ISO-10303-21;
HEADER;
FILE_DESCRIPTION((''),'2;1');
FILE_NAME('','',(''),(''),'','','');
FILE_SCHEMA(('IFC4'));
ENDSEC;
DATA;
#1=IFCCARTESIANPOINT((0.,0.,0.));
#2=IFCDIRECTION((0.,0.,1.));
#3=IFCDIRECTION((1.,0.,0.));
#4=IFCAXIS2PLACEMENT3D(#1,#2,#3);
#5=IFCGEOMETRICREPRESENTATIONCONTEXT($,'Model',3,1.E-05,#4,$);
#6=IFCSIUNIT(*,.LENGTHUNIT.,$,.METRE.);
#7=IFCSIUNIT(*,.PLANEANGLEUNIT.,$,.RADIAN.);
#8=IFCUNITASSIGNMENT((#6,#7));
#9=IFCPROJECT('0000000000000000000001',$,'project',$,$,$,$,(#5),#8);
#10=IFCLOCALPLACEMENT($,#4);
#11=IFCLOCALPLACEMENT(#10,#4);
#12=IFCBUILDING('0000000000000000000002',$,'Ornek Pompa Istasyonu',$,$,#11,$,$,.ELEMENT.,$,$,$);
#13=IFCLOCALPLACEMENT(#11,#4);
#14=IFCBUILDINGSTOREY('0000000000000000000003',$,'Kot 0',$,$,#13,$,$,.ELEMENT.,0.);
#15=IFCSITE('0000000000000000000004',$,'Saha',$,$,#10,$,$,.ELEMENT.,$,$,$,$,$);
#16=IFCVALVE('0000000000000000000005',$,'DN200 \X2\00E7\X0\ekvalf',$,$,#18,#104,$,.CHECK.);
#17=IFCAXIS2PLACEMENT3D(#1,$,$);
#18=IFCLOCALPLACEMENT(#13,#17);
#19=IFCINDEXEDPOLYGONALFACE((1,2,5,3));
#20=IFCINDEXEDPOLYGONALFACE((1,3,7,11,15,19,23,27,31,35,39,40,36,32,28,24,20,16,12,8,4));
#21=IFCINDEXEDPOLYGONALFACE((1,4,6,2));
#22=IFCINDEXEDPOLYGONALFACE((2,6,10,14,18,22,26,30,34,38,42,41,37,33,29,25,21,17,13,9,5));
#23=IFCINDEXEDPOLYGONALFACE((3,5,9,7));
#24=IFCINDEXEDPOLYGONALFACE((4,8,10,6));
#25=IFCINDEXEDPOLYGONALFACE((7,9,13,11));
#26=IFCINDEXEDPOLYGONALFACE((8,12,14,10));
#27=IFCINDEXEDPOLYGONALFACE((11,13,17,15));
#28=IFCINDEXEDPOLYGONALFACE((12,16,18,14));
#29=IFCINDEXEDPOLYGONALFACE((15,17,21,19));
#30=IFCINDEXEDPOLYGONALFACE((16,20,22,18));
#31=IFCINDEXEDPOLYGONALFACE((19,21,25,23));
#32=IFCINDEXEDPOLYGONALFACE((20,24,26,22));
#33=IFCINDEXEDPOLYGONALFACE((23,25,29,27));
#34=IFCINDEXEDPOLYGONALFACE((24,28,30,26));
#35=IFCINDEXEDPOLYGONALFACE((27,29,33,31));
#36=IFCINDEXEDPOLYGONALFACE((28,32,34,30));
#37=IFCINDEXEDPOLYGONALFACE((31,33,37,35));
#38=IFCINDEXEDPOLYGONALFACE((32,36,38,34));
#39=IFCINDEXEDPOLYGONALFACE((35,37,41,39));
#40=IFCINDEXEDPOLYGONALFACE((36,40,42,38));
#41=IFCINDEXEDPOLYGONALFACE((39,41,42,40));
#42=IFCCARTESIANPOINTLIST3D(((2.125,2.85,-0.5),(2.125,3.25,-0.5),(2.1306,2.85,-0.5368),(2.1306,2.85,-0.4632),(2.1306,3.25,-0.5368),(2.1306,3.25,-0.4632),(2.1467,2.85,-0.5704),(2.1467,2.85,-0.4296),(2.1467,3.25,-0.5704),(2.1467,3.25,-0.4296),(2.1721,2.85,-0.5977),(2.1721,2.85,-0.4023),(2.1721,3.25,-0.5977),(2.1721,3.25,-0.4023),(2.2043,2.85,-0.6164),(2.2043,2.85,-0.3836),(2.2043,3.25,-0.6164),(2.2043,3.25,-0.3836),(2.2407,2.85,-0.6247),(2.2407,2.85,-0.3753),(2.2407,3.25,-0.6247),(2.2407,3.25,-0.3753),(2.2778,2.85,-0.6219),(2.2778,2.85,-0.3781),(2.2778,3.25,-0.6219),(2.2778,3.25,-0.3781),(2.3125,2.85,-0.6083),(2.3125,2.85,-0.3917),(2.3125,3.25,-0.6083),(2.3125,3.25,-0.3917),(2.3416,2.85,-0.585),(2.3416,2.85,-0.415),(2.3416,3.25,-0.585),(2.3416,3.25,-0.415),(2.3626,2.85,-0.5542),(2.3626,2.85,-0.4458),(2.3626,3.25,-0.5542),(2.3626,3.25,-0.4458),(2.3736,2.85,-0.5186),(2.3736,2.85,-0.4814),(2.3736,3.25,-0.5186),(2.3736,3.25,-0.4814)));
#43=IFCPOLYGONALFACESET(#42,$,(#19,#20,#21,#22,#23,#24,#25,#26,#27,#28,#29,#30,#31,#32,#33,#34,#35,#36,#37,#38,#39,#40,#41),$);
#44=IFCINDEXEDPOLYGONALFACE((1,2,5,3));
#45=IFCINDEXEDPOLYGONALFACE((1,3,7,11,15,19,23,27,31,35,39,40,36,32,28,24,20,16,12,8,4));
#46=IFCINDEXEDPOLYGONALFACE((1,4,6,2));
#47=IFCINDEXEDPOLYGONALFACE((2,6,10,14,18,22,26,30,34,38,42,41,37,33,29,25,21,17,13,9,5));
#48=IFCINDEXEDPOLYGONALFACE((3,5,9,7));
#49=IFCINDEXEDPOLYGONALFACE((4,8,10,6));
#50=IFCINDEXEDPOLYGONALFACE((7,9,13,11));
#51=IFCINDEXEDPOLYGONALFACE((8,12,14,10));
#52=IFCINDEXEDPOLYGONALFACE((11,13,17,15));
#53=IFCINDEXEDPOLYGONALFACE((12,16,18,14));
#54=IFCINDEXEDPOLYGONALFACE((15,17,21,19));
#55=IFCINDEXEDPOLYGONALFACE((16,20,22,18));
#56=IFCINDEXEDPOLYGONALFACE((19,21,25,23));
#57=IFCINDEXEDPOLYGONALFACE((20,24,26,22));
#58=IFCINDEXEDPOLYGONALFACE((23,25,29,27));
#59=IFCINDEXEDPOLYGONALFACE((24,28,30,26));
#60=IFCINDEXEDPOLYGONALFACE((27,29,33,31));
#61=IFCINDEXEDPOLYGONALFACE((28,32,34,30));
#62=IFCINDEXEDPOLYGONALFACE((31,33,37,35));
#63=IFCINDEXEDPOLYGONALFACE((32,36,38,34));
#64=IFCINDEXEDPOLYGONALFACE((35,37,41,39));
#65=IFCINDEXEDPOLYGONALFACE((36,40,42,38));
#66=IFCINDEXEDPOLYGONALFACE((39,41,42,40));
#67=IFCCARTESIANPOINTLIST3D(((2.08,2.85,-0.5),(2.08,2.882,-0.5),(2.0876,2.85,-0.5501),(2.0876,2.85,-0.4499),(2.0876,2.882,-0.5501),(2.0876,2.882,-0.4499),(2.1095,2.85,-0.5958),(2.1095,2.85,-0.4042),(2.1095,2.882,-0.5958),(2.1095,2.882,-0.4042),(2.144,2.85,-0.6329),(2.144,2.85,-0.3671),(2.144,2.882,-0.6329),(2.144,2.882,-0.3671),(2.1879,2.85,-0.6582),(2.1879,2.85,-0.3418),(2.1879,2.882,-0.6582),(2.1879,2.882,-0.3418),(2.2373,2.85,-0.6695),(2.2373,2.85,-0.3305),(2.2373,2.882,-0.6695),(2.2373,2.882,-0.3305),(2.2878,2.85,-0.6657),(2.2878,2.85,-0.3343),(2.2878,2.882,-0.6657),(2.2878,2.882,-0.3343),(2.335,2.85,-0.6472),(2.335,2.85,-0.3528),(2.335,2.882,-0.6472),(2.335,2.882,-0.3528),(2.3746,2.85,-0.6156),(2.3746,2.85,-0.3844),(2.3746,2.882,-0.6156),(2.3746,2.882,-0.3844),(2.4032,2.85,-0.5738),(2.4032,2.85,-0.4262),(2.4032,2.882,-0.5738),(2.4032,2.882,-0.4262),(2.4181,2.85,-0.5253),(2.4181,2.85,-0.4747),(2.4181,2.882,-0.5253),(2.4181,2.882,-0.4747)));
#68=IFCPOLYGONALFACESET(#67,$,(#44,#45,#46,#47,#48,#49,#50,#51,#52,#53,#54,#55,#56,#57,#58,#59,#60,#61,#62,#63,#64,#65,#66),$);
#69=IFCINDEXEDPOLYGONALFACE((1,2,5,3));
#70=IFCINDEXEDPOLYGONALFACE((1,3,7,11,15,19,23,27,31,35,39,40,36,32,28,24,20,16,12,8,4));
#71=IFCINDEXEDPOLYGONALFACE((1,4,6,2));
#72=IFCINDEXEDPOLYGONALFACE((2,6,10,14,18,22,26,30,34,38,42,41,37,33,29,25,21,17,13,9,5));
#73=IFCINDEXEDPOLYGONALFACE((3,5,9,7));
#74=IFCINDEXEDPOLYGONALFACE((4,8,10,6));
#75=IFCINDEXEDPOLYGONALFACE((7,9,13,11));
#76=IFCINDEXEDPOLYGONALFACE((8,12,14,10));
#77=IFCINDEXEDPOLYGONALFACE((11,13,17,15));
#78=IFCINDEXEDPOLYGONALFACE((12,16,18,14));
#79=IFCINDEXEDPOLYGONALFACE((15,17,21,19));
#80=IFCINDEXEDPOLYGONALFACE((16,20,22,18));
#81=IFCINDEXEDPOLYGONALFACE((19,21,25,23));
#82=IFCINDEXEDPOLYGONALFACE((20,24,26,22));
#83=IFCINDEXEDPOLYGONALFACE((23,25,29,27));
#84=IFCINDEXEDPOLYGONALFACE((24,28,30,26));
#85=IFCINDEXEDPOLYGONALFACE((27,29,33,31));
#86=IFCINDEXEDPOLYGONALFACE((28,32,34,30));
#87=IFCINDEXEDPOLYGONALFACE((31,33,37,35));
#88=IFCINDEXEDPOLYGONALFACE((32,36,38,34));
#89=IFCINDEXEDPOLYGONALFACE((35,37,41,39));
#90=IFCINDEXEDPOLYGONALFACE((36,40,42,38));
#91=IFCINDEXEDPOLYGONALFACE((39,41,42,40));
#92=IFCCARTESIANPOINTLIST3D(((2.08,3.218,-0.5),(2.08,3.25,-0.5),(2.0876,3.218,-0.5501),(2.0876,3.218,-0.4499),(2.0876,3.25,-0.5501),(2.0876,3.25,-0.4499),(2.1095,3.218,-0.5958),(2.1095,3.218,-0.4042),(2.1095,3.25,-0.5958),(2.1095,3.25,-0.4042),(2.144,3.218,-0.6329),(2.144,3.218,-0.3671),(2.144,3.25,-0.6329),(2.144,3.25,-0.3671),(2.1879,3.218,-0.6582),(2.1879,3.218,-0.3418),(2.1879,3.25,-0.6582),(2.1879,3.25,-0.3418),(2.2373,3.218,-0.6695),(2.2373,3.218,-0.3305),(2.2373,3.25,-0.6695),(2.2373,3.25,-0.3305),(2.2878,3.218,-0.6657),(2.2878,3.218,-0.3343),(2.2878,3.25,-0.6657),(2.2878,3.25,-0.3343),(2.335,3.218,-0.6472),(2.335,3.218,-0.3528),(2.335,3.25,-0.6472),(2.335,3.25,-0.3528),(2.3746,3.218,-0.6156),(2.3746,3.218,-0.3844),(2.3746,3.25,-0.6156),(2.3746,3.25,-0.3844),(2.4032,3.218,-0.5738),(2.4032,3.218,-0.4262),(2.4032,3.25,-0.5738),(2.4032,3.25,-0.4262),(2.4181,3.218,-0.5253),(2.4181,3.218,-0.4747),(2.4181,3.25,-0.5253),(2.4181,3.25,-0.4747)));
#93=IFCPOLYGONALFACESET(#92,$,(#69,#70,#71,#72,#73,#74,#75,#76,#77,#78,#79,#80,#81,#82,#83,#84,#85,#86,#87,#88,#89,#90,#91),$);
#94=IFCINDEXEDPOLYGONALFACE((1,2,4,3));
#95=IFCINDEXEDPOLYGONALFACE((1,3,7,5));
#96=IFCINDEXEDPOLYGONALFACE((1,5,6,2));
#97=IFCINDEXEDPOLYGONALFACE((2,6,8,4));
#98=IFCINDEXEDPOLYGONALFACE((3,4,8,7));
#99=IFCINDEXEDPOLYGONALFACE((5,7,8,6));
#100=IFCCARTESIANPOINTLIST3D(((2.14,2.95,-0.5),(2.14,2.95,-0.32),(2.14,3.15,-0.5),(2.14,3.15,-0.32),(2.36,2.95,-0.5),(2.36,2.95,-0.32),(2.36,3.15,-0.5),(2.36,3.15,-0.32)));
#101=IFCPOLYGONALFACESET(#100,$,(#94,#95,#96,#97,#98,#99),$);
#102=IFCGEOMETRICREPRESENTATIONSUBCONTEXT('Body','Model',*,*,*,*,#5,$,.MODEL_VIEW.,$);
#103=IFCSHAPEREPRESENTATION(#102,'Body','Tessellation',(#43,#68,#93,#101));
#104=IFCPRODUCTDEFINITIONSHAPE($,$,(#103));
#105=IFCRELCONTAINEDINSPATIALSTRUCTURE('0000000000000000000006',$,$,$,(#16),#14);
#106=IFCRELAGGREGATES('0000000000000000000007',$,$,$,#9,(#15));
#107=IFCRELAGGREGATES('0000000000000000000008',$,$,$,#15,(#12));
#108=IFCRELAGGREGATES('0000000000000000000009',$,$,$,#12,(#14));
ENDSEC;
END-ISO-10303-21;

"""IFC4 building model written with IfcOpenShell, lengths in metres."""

from ifc_helpers import new_model, si_unit, frame, origin_with_axes, origin_2d, place, context, subcontext, project, spatial, polyline, circle, outline, extrude, element, save


model = new_model("IFC4")

# Units and contexts
model_context = context("Model", 3, precision=1e-05, world=origin_with_axes())
body_context = subcontext(model_context, "Body", "Model", "MODEL_VIEW")
ifc_project = project(units=[si_unit("LENGTHUNIT", "METRE"), si_unit("PLANEANGLEUNIT", "RADIAN")], contexts=[model_context])

# Site, building, storey
site_placement = place(None, origin_with_axes())
site = spatial("IfcSite", under=ifc_project, at=site_placement, Name="Saha", CompositionType="ELEMENT")
building_placement = place(site_placement, origin_with_axes())
building = spatial("IfcBuilding", under=site, at=building_placement, Name="Ornek Pompa Istasyonu", CompositionType="ELEMENT")
storey_placement = place(building_placement, origin_with_axes())
storey = spatial("IfcBuildingStorey", under=building, at=storey_placement, Name="Kot 0", CompositionType="ELEMENT", Elevation=0.0)

# Valve
valve_1_placement = place(storey_placement, origin_with_axes())
element("IfcValve", 1, at=valve_1_placement, inside=storey, Name="DN200 çekvalf", PredefinedType="CHECK", context=body_context, shape_type="SweptSolid", body=[
    extrude(circle(Radius=0.125, at=origin_2d()), frame((2.25, 2.85, -0.5), z_axis=(0.0, 1.0, 0.0), x_axis=(-1.0, 0.0, 0.0)), (0.0, 0.0, 1.0), 0.4),
    extrude(circle(Radius=0.17, at=origin_2d()), frame((2.25, 2.85, -0.5), z_axis=(0.0, 1.0, 0.0), x_axis=(-1.0, 0.0, 0.0)), (0.0, 0.0, 1.0), 0.032),
    extrude(circle(Radius=0.17, at=origin_2d()), frame((2.25, 3.218, -0.5), z_axis=(0.0, 1.0, 0.0), x_axis=(-1.0, 0.0, 0.0)), (0.0, 0.0, 1.0), 0.032),
    extrude(outline(polyline([(0.0, 0.0), (0.2, 0.0), (0.2, 0.22), (0.0, 0.22), (0.0, 0.0)])), frame((2.36, 2.95, -0.5), z_axis=(0.0, 0.0, 1.0), x_axis=(0.0, 1.0, 0.0)), (0.0, 0.0, 1.0), 0.18),
])

save(model, "model.ifc")
